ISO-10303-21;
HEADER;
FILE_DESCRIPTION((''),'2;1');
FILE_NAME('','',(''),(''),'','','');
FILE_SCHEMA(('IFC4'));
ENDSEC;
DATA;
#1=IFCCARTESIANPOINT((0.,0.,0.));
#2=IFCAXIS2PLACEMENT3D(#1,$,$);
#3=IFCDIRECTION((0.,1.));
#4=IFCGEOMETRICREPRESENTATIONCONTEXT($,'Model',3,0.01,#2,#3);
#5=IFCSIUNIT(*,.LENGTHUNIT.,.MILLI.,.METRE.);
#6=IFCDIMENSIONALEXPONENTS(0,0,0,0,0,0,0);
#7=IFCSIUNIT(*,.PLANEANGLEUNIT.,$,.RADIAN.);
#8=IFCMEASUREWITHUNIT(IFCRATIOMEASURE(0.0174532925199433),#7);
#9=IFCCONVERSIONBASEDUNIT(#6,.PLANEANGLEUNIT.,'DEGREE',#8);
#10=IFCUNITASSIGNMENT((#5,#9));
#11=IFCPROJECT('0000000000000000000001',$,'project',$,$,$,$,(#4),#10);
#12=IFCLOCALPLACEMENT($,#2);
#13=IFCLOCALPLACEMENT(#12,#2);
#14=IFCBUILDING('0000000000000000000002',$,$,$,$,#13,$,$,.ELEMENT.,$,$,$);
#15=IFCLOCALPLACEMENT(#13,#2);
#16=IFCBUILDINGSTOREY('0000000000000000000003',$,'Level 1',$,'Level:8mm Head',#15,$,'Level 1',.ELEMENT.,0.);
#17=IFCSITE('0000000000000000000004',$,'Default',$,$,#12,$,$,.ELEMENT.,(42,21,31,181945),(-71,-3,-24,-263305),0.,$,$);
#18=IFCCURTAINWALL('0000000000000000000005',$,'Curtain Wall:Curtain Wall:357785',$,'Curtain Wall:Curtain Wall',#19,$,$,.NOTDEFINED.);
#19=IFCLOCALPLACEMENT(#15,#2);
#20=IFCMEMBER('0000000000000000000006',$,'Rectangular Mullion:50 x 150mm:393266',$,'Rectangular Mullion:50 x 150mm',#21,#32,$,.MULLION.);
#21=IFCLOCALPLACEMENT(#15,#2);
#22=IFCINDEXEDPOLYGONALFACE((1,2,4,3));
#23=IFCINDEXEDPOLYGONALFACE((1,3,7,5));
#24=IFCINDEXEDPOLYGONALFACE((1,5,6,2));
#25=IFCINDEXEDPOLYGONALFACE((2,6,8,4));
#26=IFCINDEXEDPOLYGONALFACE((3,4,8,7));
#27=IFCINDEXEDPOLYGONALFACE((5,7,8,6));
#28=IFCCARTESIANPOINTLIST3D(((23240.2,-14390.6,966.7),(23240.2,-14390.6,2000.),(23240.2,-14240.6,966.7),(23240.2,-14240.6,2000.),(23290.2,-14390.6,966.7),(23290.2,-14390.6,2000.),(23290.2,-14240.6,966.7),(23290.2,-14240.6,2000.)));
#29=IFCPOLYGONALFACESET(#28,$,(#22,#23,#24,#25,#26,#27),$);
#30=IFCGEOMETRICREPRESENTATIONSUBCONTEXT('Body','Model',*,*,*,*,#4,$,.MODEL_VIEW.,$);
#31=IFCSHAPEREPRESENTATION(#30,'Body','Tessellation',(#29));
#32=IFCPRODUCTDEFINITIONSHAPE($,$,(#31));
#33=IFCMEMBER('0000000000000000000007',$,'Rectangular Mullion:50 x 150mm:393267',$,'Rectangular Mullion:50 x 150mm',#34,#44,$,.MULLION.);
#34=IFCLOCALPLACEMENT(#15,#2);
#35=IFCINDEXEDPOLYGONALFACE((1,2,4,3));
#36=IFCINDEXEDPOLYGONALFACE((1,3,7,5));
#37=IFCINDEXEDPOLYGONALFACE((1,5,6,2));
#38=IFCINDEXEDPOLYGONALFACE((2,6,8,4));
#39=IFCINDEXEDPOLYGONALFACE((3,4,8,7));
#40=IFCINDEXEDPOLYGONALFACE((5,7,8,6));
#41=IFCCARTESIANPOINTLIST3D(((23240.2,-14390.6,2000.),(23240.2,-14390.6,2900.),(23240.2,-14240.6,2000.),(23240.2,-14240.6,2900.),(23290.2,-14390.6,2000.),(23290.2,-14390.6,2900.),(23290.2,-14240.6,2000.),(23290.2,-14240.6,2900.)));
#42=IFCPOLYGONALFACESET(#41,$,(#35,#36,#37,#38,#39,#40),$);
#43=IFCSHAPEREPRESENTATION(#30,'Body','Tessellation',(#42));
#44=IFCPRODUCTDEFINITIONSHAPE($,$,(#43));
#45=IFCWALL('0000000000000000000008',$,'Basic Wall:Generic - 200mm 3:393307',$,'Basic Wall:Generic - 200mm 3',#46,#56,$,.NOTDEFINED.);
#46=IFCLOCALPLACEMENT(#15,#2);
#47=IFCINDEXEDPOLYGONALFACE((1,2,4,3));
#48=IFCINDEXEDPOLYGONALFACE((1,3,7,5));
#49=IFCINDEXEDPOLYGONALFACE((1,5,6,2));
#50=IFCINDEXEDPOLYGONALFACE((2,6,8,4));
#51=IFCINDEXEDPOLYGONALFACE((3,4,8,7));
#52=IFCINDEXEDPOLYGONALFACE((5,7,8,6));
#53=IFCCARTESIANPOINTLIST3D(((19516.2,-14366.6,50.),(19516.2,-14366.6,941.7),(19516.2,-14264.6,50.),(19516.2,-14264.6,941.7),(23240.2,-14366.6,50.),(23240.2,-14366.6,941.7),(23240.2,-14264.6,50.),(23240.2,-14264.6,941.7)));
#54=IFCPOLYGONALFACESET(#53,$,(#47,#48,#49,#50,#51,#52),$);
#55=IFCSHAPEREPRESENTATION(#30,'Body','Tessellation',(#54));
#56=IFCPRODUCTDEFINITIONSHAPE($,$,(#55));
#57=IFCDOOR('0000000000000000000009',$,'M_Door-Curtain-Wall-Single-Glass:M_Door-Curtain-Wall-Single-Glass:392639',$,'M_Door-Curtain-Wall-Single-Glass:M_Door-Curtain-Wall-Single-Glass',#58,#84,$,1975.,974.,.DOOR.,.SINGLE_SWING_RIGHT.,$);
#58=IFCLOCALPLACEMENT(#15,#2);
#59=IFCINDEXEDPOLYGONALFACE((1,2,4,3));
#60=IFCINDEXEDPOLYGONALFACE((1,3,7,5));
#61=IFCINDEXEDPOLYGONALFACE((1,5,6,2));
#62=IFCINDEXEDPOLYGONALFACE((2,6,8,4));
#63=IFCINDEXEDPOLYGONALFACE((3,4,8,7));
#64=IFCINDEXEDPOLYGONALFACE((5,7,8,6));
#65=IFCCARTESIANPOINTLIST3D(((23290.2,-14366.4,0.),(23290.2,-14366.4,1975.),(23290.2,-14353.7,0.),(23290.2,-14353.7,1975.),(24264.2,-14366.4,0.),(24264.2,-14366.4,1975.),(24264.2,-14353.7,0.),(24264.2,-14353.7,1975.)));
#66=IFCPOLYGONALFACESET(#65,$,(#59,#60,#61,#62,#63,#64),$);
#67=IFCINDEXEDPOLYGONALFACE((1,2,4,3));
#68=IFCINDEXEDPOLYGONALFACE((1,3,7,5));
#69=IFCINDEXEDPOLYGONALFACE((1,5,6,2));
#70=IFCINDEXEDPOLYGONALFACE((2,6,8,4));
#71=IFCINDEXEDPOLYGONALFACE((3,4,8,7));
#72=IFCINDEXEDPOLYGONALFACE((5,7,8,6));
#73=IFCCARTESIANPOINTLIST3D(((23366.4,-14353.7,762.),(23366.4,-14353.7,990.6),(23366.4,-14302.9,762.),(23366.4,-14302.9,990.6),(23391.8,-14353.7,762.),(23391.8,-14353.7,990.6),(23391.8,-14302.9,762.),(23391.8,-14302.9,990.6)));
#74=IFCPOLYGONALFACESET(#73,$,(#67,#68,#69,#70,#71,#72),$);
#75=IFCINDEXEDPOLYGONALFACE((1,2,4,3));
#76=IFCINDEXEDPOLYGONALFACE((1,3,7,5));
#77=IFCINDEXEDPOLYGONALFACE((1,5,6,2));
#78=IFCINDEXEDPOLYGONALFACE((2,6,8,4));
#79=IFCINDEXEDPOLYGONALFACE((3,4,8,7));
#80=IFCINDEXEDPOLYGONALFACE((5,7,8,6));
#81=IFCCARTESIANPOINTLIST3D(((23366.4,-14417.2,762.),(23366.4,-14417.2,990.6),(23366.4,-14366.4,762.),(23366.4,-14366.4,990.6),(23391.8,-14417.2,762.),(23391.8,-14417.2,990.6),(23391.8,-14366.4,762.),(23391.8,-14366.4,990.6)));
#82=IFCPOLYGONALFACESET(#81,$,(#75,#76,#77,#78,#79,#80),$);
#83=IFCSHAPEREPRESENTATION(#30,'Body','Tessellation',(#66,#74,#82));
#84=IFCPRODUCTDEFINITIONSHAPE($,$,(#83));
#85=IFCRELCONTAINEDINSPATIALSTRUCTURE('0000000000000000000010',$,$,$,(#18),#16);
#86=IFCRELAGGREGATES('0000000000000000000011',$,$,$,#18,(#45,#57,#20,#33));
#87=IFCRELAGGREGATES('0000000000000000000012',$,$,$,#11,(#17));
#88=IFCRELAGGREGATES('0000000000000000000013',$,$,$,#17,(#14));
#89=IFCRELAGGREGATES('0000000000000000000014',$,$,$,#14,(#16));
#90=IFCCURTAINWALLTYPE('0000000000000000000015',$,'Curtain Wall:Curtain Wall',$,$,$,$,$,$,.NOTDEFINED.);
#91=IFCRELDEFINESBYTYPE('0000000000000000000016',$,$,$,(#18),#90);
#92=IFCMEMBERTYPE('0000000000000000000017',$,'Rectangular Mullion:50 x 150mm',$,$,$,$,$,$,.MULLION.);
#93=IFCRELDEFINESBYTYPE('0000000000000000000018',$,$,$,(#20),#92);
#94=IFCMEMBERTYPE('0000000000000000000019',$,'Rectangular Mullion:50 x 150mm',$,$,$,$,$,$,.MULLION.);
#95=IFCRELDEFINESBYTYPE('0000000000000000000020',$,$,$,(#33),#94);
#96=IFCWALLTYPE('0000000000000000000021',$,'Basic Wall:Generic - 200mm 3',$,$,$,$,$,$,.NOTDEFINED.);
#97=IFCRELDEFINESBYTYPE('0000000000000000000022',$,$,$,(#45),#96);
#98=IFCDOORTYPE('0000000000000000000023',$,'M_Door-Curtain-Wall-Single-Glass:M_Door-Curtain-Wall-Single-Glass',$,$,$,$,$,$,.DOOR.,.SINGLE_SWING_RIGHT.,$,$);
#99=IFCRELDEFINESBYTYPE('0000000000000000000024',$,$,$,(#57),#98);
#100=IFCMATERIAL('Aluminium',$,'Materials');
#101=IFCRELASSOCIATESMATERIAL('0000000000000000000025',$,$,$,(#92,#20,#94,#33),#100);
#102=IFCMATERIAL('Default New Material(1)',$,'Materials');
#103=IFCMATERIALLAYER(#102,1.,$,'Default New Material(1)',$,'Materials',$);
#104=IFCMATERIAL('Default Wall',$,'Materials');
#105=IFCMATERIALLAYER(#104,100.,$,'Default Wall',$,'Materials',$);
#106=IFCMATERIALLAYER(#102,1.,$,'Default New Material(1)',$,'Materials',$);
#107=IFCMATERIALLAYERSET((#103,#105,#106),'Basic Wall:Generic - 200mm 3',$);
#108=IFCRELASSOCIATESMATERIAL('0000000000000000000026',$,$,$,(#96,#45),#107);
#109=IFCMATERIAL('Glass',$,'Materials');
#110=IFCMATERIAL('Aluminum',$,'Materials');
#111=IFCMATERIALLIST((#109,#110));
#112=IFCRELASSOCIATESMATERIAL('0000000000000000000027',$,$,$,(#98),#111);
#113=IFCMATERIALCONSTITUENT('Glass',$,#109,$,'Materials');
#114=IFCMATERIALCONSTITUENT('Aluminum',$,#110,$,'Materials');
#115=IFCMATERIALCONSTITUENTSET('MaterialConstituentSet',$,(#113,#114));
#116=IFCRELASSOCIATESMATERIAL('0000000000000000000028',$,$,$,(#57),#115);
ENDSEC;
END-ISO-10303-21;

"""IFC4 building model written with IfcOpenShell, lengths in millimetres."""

from ifc_helpers import new_model, entity, si_unit, converted_unit, direction, frame, origin, place, context, subcontext, project, spatial, indexed_curve, outline, extrude, source, transform, mapped, material, material_list, layer, layer_set, constituent, constituent_set, type_object, type_shapes, element, aggregate, save


model = new_model("IFC4")

# Units and contexts
model_context = context("Model", 3, precision=0.01, world=origin(), true_north=direction((0.0, 1.0)))
body_context = subcontext(model_context, "Body", "Model", "MODEL_VIEW")
ifc_project = project(units=[si_unit("LENGTHUNIT", "METRE", prefix="MILLI"), converted_unit("PLANEANGLEUNIT", "DEGREE", entity("IfcRatioMeasure", 0.0174532925199433), si_unit("PLANEANGLEUNIT", "RADIAN"), dimensions=[0, 0, 0, 0, 0, 0, 0])], contexts=[model_context])

# Site, building, storey
site_placement = place(None, origin())
site = spatial("IfcSite", under=ifc_project, at=site_placement, Name="Default", CompositionType="ELEMENT", RefLatitude=(42, 21, 31, 181945), RefLongitude=(-71, -3, -24, -263305), RefElevation=0.0)
building_placement = place(site_placement, origin())
building = spatial("IfcBuilding", under=site, at=building_placement, CompositionType="ELEMENT")
storey_placement = place(building_placement, origin())
storey = spatial("IfcBuildingStorey", under=building, at=storey_placement, Name="Level 1", ObjectType="Level:8mm Head", LongName="Level 1", CompositionType="ELEMENT", Elevation=0.0)

# Curtain wall, members
ifc_material_1 = material(Name="Aluminium", Category="Materials")
curtain_wall_type_1 = type_object("IfcCurtainWallType", Name="Curtain Wall:Curtain Wall", PredefinedType="NOTDEFINED")
curtain_wall_1_placement = place(storey_placement, origin())
curtain_wall_1 = element("IfcCurtainWall", 1, at=curtain_wall_1_placement, inside=storey, type_object=curtain_wall_type_1, Name="Curtain Wall:Curtain Wall:357785", ObjectType="Curtain Wall:Curtain Wall", PredefinedType="NOTDEFINED")
member_type_1 = type_object("IfcMemberType", Name="Rectangular Mullion:50 x 150mm", PredefinedType="MULLION", material=ifc_material_1)
shared_shape_1 = source(origin(), body_context, "Body", "SweptSolid", [
    extrude(outline(indexed_curve([(-75.0, -25.0), (75.0, -25.0), (75.0, 25.0), (-75.0, 25.0), (-75.0, -25.0)], self_intersect=False)), frame((0.0, 0.0, -1033.3), z_axis=(0.0, 0.0, 1.0), x_axis=(0.0, -1.0, 0.0)), (0.0, 0.0, 1.0), 1033.3),
])
type_shapes(member_type_1, [shared_shape_1])
member_1_placement = place(storey_placement, frame((23265.2, -14315.6, 966.7), z_axis=(0.0, 0.0, -1.0), x_axis=(1.0, 0.0, 0.0)))
member_1 = element("IfcMember", 2, at=member_1_placement, type_object=member_type_1, material=ifc_material_1, Name="Rectangular Mullion:50 x 150mm:393266", ObjectType="Rectangular Mullion:50 x 150mm", PredefinedType="MULLION", context=body_context, shape_type="MappedRepresentation", body=[
    mapped(shared_shape_1, transform((0.0, 0.0, 0.0), scale=1.0)),
])
member_type_2 = type_object("IfcMemberType", Name="Rectangular Mullion:50 x 150mm", PredefinedType="MULLION", material=ifc_material_1)
shared_shape_2 = source(origin(), body_context, "Body", "SweptSolid", [
    extrude(outline(indexed_curve([(-75.0, -25.0), (75.0, -25.0), (75.0, 25.0), (-75.0, 25.0), (-75.0, -25.0)], self_intersect=False)), frame((0.0, 0.0, -900.0), z_axis=(0.0, 0.0, 1.0), x_axis=(0.0, -1.0, 0.0)), (0.0, 0.0, 1.0), 900.0),
])
type_shapes(member_type_2, [shared_shape_2])
member_2_placement = place(storey_placement, frame((23265.2, -14315.6, 2000.0), z_axis=(0.0, 0.0, -1.0), x_axis=(1.0, 0.0, 0.0)))
member_2 = element("IfcMember", 3, at=member_2_placement, type_object=member_type_2, material=ifc_material_1, Name="Rectangular Mullion:50 x 150mm:393267", ObjectType="Rectangular Mullion:50 x 150mm", PredefinedType="MULLION", context=body_context, shape_type="MappedRepresentation", body=[
    mapped(shared_shape_2, transform((0.0, 0.0, 0.0), scale=1.0)),
])

# Shared definitions
ifc_material_2 = material(Name="Glass", Category="Materials")

# Wall
ifc_material_3 = material(Name="Default New Material(1)", Category="Materials")
ifc_layer_1 = layer(ifc_material_3, 1.0, Name="Default New Material(1)", Category="Materials")
ifc_material_4 = material(Name="Default Wall", Category="Materials")
ifc_layer_2 = layer(ifc_material_4, 100.0, Name="Default Wall", Category="Materials")
ifc_layer_3 = layer(ifc_material_3, 1.0, Name="Default New Material(1)", Category="Materials")
ifc_layer_set = layer_set([ifc_layer_1, ifc_layer_2, ifc_layer_3], Name="Basic Wall:Generic - 200mm 3")
wall_type = type_object("IfcWallType", Name="Basic Wall:Generic - 200mm 3", PredefinedType="NOTDEFINED", material=ifc_layer_set)
wall_placement = place(storey_placement, frame((19516.2, -14315.6, 50.0)))
wall = element("IfcWall", 4, at=wall_placement, type_object=wall_type, material=ifc_layer_set, Name="Basic Wall:Generic - 200mm 3:393307", ObjectType="Basic Wall:Generic - 200mm 3", PredefinedType="NOTDEFINED", context=body_context, shape_type="SweptSolid", body=[
    extrude(outline(indexed_curve([(3724.0, 51.0), (0.0, 51.0), (0.0, -51.0), (3724.0, -51.0), (3724.0, 51.0)], self_intersect=False)), origin(), (0.0, 0.0, 1.0), 891.7),
])

# Door
ifc_constituent_1 = constituent(ifc_material_2, Name="Glass", Category="Materials")
ifc_material_5 = material(Name="Aluminum", Category="Materials")
ifc_constituent_2 = constituent(ifc_material_5, Name="Aluminum", Category="Materials")
ifc_constituent_set_1 = constituent_set(constituents=[ifc_constituent_1, ifc_constituent_2], Name="MaterialConstituentSet")
ifc_material_list_1 = material_list([ifc_material_2, ifc_material_5])
door_type = type_object("IfcDoorType", Name="M_Door-Curtain-Wall-Single-Glass:M_Door-Curtain-Wall-Single-Glass", OperationType="SINGLE_SWING_RIGHT", PredefinedType="DOOR", material=ifc_material_list_1)
shared_shape_3 = source(origin(), body_context, "Body", "SweptSolid", [
    extrude(outline(indexed_curve([(-6.4, -487.0), (6.4, -487.0), (6.4, 487.0), (-6.4, 487.0), (-6.4, -487.0)], self_intersect=False)), frame((0.0, -44.5, 0.0), z_axis=(0.0, 0.0, 1.0), x_axis=(0.0, 1.0, 0.0)), (0.0, 0.0, 1.0), 1975.0),
    extrude(outline(indexed_curve([(-12.7, -25.4), (12.7, -25.4), (12.7, 25.4), (-12.7, 25.4), (-12.7, -25.4)], self_intersect=False)), frame((-398.1, -12.7, 762.0), z_axis=(0.0, 0.0, 1.0), x_axis=(-1.0, 0.0, 0.0)), (0.0, 0.0, 1.0), 228.6),
    extrude(outline(indexed_curve([(-12.7, -25.4), (12.7, -25.4), (12.7, 25.4), (-12.7, 25.4), (-12.7, -25.4)], self_intersect=False)), frame((-398.1, -76.2, 762.0)), (0.0, 0.0, 1.0), 228.6),
])
type_shapes(door_type, [shared_shape_3])
door_placement = place(curtain_wall_1_placement, frame((23777.2, -14315.6, 0.0)))
door = element("IfcDoor", 5, at=door_placement, type_object=door_type, material=ifc_constituent_set_1, Name="M_Door-Curtain-Wall-Single-Glass:M_Door-Curtain-Wall-Single-Glass:392639", ObjectType="M_Door-Curtain-Wall-Single-Glass:M_Door-Curtain-Wall-Single-Glass", OperationType="SINGLE_SWING_RIGHT", OverallHeight=1975.0, OverallWidth=974.0, PredefinedType="DOOR", context=body_context, shape_type="MappedRepresentation", body=[
    mapped(shared_shape_3, transform((0.0, 0.0, 0.0), scale=1.0)),
])
aggregate(curtain_wall_1, [wall, door, member_1, member_2])

save(model, "model.ifc")
